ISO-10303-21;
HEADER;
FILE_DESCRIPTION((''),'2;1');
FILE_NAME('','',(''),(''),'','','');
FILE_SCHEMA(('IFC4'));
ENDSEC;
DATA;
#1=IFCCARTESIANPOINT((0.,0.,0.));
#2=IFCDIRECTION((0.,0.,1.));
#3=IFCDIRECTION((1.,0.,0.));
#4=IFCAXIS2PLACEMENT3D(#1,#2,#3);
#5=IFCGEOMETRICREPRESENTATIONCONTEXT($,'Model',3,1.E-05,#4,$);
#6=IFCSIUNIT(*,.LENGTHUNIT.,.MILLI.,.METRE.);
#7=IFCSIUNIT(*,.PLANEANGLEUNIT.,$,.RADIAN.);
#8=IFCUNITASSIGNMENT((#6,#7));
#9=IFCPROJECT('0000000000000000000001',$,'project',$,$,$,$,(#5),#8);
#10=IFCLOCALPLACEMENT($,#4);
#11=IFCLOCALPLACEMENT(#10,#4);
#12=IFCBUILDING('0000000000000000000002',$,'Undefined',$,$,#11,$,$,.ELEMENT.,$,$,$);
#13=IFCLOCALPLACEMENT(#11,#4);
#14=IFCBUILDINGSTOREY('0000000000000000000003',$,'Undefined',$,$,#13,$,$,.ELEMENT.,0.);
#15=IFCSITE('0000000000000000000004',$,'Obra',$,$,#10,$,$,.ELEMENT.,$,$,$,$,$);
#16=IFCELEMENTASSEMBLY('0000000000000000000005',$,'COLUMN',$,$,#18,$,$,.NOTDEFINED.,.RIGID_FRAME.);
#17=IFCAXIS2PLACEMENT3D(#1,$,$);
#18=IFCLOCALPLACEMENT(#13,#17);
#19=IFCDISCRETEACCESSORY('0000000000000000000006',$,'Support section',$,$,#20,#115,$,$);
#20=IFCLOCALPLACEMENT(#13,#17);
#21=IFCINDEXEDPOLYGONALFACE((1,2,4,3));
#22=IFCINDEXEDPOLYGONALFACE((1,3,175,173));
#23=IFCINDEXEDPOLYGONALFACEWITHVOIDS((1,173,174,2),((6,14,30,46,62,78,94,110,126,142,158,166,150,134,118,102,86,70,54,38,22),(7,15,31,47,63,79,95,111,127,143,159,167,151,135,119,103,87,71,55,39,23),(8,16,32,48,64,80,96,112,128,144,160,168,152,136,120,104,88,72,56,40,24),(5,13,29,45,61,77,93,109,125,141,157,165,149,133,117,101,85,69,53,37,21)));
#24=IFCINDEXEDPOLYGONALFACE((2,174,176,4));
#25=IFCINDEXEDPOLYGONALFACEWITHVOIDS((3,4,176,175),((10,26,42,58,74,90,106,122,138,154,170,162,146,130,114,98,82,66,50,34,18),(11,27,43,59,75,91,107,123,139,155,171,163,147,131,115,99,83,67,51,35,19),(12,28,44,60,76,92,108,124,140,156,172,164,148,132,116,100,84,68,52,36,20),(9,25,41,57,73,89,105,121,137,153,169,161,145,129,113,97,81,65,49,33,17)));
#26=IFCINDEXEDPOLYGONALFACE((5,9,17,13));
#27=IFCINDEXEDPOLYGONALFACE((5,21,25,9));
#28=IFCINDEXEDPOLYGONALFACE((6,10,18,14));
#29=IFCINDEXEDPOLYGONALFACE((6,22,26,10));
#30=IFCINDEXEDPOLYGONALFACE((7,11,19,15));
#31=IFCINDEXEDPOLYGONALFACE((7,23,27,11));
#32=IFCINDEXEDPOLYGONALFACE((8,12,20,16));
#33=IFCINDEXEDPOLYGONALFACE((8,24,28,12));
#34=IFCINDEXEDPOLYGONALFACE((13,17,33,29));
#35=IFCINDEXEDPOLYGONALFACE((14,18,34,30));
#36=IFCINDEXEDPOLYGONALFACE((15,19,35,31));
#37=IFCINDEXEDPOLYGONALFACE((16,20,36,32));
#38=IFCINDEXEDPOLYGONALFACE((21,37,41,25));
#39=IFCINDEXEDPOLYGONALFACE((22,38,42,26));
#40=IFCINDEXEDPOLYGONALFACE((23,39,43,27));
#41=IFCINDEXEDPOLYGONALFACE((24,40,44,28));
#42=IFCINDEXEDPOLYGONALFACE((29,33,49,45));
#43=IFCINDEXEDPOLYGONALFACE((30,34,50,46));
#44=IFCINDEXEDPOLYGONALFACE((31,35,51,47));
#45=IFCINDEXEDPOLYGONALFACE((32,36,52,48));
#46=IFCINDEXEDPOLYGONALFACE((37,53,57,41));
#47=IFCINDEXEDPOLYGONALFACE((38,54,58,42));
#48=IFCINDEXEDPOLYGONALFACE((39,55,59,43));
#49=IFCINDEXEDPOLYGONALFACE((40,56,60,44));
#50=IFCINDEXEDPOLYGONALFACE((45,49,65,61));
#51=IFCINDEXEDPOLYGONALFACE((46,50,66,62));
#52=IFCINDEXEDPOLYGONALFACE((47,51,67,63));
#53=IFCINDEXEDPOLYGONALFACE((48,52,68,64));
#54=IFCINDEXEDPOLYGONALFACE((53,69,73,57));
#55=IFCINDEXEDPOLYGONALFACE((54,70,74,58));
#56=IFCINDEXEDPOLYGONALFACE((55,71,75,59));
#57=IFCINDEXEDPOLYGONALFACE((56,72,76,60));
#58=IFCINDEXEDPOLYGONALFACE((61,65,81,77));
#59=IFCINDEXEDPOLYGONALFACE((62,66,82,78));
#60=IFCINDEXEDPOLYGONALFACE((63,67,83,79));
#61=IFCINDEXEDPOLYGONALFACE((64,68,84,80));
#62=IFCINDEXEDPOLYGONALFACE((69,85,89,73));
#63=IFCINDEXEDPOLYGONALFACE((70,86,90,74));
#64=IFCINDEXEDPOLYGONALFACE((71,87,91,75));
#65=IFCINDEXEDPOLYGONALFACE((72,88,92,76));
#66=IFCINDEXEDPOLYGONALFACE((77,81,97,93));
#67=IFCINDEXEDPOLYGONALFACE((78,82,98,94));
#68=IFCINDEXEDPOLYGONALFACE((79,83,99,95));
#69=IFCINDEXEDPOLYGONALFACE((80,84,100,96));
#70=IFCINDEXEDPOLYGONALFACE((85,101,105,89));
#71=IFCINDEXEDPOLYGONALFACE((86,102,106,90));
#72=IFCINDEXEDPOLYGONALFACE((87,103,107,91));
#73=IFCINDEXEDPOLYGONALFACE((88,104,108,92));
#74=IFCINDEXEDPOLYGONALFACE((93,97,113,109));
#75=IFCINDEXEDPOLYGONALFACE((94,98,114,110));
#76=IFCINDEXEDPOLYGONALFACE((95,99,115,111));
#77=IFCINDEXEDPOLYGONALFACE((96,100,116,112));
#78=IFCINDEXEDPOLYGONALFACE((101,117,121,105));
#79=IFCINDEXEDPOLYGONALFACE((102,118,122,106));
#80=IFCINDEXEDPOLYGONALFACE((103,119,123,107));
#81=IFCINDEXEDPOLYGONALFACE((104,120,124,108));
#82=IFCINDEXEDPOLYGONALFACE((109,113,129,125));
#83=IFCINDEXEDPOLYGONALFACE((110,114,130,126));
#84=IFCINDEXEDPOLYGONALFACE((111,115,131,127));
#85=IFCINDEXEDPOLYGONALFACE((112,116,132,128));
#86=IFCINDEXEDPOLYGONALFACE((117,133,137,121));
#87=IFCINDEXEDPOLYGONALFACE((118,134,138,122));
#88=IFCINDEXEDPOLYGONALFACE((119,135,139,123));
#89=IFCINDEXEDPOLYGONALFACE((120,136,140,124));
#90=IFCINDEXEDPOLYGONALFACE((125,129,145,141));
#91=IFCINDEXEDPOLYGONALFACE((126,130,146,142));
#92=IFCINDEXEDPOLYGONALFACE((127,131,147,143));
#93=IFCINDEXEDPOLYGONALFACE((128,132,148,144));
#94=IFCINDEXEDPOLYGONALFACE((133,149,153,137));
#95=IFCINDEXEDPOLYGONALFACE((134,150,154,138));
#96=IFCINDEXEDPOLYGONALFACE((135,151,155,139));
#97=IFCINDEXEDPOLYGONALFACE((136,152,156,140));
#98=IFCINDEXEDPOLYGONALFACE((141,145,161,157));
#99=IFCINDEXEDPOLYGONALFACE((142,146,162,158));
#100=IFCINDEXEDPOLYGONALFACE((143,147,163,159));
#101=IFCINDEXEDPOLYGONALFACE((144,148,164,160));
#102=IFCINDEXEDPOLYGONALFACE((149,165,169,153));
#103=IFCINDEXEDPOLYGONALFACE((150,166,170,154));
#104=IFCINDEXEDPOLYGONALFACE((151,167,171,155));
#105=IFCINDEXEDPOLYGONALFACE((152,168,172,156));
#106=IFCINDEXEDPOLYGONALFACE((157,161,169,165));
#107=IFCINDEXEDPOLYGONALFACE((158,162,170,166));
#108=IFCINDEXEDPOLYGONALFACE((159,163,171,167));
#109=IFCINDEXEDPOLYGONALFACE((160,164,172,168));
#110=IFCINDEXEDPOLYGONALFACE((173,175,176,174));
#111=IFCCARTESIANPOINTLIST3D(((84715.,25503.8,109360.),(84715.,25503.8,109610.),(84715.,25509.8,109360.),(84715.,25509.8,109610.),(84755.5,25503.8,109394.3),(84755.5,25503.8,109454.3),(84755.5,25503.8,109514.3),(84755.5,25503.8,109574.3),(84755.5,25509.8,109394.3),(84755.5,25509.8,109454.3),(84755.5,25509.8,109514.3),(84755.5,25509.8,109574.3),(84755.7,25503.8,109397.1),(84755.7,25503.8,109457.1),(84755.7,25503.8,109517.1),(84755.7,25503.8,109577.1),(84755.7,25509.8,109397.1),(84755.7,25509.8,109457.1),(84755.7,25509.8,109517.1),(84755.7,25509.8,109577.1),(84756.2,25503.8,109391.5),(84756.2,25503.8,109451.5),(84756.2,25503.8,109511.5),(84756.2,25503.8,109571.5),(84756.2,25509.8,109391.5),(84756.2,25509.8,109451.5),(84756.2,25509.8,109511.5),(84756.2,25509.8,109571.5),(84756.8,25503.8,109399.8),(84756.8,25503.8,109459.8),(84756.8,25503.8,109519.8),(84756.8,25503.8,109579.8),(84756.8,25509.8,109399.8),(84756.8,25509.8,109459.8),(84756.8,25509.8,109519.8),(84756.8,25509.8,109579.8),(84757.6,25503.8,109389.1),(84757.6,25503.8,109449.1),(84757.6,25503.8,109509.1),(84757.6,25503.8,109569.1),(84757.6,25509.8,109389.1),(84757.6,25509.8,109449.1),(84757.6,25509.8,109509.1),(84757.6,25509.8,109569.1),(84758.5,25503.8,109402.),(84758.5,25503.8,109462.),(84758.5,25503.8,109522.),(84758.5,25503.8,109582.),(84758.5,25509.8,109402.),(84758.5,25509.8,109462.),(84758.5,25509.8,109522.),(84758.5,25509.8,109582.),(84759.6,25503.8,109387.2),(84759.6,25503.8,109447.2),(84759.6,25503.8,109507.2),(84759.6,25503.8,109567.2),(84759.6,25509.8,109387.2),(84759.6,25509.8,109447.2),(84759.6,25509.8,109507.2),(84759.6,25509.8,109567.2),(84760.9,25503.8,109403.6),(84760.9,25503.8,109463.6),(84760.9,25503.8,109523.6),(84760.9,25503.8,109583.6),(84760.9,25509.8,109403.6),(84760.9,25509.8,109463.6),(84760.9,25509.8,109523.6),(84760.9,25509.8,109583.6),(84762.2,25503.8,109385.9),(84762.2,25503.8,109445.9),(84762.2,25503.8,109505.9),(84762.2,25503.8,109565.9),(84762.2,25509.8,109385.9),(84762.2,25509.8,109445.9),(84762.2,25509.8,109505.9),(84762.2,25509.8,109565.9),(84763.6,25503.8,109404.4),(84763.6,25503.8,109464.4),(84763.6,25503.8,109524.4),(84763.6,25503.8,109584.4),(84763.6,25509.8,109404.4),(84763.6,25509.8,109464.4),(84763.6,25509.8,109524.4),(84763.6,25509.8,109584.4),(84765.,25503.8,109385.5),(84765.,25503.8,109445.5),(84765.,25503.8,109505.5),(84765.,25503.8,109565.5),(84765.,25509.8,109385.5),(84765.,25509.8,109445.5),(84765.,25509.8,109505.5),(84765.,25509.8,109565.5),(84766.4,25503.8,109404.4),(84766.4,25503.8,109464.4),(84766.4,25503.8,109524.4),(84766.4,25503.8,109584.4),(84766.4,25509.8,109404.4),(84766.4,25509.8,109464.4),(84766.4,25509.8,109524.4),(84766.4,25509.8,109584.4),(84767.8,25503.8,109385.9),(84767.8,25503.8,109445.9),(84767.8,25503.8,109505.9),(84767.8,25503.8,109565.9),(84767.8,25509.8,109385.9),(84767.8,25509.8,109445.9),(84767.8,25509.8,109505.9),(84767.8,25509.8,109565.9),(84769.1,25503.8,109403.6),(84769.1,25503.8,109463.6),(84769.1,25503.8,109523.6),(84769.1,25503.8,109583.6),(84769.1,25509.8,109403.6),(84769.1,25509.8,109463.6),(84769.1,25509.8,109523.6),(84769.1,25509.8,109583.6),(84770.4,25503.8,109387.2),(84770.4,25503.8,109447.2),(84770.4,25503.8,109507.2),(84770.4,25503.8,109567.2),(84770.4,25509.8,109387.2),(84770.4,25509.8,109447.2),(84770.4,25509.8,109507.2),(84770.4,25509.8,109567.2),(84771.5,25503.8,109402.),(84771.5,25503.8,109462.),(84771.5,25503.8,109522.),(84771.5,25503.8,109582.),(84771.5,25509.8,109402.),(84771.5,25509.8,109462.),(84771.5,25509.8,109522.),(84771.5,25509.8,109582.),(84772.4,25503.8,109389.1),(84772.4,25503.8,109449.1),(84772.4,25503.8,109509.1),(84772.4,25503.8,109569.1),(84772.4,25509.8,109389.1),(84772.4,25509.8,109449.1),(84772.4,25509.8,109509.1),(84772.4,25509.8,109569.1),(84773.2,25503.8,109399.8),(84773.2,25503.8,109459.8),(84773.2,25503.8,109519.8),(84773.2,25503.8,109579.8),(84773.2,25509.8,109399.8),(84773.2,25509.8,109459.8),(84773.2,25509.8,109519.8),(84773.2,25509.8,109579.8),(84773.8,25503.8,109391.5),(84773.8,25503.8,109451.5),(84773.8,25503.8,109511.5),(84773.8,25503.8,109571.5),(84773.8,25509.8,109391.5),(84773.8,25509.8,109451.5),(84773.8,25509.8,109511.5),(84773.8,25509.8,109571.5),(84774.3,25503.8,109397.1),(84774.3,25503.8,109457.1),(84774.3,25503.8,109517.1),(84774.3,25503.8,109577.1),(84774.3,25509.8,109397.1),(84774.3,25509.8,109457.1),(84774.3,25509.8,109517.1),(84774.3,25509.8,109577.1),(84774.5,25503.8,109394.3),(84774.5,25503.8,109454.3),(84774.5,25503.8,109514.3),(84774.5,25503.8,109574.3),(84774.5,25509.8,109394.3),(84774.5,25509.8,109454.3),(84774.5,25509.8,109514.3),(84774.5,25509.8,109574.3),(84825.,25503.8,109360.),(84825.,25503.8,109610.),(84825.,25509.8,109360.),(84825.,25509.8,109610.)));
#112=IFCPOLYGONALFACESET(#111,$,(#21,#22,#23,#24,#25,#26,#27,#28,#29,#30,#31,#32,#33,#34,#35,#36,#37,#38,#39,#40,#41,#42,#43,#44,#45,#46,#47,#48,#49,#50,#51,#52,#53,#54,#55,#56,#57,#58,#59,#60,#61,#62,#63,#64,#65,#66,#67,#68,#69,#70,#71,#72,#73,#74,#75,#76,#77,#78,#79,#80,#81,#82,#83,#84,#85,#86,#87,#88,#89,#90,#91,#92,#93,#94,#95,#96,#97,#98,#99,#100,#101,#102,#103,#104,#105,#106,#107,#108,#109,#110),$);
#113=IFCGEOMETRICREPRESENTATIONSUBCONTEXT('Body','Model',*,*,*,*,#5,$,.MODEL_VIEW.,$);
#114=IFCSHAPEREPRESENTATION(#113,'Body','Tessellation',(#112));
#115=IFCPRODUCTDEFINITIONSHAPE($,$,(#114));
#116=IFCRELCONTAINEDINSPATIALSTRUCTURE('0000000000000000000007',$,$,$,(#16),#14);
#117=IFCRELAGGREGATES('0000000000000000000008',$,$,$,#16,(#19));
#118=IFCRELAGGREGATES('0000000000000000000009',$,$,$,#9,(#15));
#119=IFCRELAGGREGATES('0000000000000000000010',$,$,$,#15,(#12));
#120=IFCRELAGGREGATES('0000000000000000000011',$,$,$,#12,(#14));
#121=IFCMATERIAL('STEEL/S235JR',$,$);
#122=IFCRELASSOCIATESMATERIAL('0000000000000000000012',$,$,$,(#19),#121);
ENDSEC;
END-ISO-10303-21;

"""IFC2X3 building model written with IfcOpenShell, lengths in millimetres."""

from ifc_helpers import new_model, si_unit, frame, origin_with_axes, origin_2d_with_axis, place, context, subcontext, project, spatial, rectangle, circle, extrude, source, transform, mapped, material, element, aggregate, save


model = new_model("IFC2X3")

# Units and contexts
model_context = context("Model", 3, precision=1e-05, world=origin_with_axes())
body_context = subcontext(model_context, "Body", "Model", "MODEL_VIEW")
ifc_project = project(units=[si_unit("LENGTHUNIT", "METRE", prefix="MILLI"), si_unit("PLANEANGLEUNIT", "RADIAN")], contexts=[model_context])

# Site, building, storey
site_placement = place(None, origin_with_axes())
site = spatial("IfcSite", under=ifc_project, at=site_placement, Name="Obra", CompositionType="ELEMENT")
building_placement = place(site_placement, origin_with_axes())
building = spatial("IfcBuilding", under=site, at=building_placement, Name="Undefined", CompositionType="ELEMENT")
storey_placement = place(building_placement, origin_with_axes())
storey = spatial("IfcBuildingStorey", under=building, at=storey_placement, Name="Undefined", CompositionType="ELEMENT", Elevation=0.0)

# Shared definitions
ifc_material_1 = material(Name="STEEL/S235JR")

# Element assembly, discrete accessory, opening
assembly_1_placement = place(storey_placement, origin_with_axes())
assembly_1 = element("IfcElementAssembly", 1, at=assembly_1_placement, inside=storey, Name="COLUMN", AssemblyPlace="NOTDEFINED", PredefinedType="RIGID_FRAME")
shared_shape_1 = source(origin_with_axes(), body_context, "Body", "SweptSolid", [
    extrude(circle(Radius=9.5, at=origin_2d_with_axis()), frame((0.0, -9.8, 0.0), z_axis=(0.0, 1.0, 0.0), x_axis=(1.0, 0.0, 0.0)), (0.0, 0.0, 1.0), 6.2),
])
discrete_accessory_1_placement = place(assembly_1_placement, frame((84770.0, 25506.8, 109360.0), z_axis=(0.0, 0.0, 1.0), x_axis=(1.0, 0.0, 0.0)))
discrete_accessory_1 = element("IfcDiscreteAccessory", 2, at=discrete_accessory_1_placement, material=ifc_material_1, Name="Support section", context=body_context, shape_type="SweptSolid", body=[
    extrude(rectangle(XDim=6.0, YDim=110.0, at=origin_2d_with_axis()), frame((0.0, 0.0, 250.0), z_axis=(0.0, 0.0, -1.0), x_axis=(0.0, 1.0, 0.0)), (0.0, 0.0, 1.0), 250.0),
])
opening_1_placement = place(assembly_1_placement, frame((84815.0, 25500.0, 109650.0), z_axis=(-1.0, 0.0, 0.0), x_axis=(0.0, 0.0, -1.0)))
element("IfcOpeningElement", 3, at=opening_1_placement, cuts=discrete_accessory_1, ObjectType="Opening", context=body_context, shape_type="MappedRepresentation", body=[
    mapped(shared_shape_1, transform((75.0, 0.0, 50.0))),
    mapped(shared_shape_1, transform((135.0, 0.0, 50.0))),
    mapped(shared_shape_1, transform((195.0, 0.0, 50.0))),
    mapped(shared_shape_1, transform((255.0, 0.0, 50.0))),
])
aggregate(assembly_1, [discrete_accessory_1])

save(model, "model.ifc")
